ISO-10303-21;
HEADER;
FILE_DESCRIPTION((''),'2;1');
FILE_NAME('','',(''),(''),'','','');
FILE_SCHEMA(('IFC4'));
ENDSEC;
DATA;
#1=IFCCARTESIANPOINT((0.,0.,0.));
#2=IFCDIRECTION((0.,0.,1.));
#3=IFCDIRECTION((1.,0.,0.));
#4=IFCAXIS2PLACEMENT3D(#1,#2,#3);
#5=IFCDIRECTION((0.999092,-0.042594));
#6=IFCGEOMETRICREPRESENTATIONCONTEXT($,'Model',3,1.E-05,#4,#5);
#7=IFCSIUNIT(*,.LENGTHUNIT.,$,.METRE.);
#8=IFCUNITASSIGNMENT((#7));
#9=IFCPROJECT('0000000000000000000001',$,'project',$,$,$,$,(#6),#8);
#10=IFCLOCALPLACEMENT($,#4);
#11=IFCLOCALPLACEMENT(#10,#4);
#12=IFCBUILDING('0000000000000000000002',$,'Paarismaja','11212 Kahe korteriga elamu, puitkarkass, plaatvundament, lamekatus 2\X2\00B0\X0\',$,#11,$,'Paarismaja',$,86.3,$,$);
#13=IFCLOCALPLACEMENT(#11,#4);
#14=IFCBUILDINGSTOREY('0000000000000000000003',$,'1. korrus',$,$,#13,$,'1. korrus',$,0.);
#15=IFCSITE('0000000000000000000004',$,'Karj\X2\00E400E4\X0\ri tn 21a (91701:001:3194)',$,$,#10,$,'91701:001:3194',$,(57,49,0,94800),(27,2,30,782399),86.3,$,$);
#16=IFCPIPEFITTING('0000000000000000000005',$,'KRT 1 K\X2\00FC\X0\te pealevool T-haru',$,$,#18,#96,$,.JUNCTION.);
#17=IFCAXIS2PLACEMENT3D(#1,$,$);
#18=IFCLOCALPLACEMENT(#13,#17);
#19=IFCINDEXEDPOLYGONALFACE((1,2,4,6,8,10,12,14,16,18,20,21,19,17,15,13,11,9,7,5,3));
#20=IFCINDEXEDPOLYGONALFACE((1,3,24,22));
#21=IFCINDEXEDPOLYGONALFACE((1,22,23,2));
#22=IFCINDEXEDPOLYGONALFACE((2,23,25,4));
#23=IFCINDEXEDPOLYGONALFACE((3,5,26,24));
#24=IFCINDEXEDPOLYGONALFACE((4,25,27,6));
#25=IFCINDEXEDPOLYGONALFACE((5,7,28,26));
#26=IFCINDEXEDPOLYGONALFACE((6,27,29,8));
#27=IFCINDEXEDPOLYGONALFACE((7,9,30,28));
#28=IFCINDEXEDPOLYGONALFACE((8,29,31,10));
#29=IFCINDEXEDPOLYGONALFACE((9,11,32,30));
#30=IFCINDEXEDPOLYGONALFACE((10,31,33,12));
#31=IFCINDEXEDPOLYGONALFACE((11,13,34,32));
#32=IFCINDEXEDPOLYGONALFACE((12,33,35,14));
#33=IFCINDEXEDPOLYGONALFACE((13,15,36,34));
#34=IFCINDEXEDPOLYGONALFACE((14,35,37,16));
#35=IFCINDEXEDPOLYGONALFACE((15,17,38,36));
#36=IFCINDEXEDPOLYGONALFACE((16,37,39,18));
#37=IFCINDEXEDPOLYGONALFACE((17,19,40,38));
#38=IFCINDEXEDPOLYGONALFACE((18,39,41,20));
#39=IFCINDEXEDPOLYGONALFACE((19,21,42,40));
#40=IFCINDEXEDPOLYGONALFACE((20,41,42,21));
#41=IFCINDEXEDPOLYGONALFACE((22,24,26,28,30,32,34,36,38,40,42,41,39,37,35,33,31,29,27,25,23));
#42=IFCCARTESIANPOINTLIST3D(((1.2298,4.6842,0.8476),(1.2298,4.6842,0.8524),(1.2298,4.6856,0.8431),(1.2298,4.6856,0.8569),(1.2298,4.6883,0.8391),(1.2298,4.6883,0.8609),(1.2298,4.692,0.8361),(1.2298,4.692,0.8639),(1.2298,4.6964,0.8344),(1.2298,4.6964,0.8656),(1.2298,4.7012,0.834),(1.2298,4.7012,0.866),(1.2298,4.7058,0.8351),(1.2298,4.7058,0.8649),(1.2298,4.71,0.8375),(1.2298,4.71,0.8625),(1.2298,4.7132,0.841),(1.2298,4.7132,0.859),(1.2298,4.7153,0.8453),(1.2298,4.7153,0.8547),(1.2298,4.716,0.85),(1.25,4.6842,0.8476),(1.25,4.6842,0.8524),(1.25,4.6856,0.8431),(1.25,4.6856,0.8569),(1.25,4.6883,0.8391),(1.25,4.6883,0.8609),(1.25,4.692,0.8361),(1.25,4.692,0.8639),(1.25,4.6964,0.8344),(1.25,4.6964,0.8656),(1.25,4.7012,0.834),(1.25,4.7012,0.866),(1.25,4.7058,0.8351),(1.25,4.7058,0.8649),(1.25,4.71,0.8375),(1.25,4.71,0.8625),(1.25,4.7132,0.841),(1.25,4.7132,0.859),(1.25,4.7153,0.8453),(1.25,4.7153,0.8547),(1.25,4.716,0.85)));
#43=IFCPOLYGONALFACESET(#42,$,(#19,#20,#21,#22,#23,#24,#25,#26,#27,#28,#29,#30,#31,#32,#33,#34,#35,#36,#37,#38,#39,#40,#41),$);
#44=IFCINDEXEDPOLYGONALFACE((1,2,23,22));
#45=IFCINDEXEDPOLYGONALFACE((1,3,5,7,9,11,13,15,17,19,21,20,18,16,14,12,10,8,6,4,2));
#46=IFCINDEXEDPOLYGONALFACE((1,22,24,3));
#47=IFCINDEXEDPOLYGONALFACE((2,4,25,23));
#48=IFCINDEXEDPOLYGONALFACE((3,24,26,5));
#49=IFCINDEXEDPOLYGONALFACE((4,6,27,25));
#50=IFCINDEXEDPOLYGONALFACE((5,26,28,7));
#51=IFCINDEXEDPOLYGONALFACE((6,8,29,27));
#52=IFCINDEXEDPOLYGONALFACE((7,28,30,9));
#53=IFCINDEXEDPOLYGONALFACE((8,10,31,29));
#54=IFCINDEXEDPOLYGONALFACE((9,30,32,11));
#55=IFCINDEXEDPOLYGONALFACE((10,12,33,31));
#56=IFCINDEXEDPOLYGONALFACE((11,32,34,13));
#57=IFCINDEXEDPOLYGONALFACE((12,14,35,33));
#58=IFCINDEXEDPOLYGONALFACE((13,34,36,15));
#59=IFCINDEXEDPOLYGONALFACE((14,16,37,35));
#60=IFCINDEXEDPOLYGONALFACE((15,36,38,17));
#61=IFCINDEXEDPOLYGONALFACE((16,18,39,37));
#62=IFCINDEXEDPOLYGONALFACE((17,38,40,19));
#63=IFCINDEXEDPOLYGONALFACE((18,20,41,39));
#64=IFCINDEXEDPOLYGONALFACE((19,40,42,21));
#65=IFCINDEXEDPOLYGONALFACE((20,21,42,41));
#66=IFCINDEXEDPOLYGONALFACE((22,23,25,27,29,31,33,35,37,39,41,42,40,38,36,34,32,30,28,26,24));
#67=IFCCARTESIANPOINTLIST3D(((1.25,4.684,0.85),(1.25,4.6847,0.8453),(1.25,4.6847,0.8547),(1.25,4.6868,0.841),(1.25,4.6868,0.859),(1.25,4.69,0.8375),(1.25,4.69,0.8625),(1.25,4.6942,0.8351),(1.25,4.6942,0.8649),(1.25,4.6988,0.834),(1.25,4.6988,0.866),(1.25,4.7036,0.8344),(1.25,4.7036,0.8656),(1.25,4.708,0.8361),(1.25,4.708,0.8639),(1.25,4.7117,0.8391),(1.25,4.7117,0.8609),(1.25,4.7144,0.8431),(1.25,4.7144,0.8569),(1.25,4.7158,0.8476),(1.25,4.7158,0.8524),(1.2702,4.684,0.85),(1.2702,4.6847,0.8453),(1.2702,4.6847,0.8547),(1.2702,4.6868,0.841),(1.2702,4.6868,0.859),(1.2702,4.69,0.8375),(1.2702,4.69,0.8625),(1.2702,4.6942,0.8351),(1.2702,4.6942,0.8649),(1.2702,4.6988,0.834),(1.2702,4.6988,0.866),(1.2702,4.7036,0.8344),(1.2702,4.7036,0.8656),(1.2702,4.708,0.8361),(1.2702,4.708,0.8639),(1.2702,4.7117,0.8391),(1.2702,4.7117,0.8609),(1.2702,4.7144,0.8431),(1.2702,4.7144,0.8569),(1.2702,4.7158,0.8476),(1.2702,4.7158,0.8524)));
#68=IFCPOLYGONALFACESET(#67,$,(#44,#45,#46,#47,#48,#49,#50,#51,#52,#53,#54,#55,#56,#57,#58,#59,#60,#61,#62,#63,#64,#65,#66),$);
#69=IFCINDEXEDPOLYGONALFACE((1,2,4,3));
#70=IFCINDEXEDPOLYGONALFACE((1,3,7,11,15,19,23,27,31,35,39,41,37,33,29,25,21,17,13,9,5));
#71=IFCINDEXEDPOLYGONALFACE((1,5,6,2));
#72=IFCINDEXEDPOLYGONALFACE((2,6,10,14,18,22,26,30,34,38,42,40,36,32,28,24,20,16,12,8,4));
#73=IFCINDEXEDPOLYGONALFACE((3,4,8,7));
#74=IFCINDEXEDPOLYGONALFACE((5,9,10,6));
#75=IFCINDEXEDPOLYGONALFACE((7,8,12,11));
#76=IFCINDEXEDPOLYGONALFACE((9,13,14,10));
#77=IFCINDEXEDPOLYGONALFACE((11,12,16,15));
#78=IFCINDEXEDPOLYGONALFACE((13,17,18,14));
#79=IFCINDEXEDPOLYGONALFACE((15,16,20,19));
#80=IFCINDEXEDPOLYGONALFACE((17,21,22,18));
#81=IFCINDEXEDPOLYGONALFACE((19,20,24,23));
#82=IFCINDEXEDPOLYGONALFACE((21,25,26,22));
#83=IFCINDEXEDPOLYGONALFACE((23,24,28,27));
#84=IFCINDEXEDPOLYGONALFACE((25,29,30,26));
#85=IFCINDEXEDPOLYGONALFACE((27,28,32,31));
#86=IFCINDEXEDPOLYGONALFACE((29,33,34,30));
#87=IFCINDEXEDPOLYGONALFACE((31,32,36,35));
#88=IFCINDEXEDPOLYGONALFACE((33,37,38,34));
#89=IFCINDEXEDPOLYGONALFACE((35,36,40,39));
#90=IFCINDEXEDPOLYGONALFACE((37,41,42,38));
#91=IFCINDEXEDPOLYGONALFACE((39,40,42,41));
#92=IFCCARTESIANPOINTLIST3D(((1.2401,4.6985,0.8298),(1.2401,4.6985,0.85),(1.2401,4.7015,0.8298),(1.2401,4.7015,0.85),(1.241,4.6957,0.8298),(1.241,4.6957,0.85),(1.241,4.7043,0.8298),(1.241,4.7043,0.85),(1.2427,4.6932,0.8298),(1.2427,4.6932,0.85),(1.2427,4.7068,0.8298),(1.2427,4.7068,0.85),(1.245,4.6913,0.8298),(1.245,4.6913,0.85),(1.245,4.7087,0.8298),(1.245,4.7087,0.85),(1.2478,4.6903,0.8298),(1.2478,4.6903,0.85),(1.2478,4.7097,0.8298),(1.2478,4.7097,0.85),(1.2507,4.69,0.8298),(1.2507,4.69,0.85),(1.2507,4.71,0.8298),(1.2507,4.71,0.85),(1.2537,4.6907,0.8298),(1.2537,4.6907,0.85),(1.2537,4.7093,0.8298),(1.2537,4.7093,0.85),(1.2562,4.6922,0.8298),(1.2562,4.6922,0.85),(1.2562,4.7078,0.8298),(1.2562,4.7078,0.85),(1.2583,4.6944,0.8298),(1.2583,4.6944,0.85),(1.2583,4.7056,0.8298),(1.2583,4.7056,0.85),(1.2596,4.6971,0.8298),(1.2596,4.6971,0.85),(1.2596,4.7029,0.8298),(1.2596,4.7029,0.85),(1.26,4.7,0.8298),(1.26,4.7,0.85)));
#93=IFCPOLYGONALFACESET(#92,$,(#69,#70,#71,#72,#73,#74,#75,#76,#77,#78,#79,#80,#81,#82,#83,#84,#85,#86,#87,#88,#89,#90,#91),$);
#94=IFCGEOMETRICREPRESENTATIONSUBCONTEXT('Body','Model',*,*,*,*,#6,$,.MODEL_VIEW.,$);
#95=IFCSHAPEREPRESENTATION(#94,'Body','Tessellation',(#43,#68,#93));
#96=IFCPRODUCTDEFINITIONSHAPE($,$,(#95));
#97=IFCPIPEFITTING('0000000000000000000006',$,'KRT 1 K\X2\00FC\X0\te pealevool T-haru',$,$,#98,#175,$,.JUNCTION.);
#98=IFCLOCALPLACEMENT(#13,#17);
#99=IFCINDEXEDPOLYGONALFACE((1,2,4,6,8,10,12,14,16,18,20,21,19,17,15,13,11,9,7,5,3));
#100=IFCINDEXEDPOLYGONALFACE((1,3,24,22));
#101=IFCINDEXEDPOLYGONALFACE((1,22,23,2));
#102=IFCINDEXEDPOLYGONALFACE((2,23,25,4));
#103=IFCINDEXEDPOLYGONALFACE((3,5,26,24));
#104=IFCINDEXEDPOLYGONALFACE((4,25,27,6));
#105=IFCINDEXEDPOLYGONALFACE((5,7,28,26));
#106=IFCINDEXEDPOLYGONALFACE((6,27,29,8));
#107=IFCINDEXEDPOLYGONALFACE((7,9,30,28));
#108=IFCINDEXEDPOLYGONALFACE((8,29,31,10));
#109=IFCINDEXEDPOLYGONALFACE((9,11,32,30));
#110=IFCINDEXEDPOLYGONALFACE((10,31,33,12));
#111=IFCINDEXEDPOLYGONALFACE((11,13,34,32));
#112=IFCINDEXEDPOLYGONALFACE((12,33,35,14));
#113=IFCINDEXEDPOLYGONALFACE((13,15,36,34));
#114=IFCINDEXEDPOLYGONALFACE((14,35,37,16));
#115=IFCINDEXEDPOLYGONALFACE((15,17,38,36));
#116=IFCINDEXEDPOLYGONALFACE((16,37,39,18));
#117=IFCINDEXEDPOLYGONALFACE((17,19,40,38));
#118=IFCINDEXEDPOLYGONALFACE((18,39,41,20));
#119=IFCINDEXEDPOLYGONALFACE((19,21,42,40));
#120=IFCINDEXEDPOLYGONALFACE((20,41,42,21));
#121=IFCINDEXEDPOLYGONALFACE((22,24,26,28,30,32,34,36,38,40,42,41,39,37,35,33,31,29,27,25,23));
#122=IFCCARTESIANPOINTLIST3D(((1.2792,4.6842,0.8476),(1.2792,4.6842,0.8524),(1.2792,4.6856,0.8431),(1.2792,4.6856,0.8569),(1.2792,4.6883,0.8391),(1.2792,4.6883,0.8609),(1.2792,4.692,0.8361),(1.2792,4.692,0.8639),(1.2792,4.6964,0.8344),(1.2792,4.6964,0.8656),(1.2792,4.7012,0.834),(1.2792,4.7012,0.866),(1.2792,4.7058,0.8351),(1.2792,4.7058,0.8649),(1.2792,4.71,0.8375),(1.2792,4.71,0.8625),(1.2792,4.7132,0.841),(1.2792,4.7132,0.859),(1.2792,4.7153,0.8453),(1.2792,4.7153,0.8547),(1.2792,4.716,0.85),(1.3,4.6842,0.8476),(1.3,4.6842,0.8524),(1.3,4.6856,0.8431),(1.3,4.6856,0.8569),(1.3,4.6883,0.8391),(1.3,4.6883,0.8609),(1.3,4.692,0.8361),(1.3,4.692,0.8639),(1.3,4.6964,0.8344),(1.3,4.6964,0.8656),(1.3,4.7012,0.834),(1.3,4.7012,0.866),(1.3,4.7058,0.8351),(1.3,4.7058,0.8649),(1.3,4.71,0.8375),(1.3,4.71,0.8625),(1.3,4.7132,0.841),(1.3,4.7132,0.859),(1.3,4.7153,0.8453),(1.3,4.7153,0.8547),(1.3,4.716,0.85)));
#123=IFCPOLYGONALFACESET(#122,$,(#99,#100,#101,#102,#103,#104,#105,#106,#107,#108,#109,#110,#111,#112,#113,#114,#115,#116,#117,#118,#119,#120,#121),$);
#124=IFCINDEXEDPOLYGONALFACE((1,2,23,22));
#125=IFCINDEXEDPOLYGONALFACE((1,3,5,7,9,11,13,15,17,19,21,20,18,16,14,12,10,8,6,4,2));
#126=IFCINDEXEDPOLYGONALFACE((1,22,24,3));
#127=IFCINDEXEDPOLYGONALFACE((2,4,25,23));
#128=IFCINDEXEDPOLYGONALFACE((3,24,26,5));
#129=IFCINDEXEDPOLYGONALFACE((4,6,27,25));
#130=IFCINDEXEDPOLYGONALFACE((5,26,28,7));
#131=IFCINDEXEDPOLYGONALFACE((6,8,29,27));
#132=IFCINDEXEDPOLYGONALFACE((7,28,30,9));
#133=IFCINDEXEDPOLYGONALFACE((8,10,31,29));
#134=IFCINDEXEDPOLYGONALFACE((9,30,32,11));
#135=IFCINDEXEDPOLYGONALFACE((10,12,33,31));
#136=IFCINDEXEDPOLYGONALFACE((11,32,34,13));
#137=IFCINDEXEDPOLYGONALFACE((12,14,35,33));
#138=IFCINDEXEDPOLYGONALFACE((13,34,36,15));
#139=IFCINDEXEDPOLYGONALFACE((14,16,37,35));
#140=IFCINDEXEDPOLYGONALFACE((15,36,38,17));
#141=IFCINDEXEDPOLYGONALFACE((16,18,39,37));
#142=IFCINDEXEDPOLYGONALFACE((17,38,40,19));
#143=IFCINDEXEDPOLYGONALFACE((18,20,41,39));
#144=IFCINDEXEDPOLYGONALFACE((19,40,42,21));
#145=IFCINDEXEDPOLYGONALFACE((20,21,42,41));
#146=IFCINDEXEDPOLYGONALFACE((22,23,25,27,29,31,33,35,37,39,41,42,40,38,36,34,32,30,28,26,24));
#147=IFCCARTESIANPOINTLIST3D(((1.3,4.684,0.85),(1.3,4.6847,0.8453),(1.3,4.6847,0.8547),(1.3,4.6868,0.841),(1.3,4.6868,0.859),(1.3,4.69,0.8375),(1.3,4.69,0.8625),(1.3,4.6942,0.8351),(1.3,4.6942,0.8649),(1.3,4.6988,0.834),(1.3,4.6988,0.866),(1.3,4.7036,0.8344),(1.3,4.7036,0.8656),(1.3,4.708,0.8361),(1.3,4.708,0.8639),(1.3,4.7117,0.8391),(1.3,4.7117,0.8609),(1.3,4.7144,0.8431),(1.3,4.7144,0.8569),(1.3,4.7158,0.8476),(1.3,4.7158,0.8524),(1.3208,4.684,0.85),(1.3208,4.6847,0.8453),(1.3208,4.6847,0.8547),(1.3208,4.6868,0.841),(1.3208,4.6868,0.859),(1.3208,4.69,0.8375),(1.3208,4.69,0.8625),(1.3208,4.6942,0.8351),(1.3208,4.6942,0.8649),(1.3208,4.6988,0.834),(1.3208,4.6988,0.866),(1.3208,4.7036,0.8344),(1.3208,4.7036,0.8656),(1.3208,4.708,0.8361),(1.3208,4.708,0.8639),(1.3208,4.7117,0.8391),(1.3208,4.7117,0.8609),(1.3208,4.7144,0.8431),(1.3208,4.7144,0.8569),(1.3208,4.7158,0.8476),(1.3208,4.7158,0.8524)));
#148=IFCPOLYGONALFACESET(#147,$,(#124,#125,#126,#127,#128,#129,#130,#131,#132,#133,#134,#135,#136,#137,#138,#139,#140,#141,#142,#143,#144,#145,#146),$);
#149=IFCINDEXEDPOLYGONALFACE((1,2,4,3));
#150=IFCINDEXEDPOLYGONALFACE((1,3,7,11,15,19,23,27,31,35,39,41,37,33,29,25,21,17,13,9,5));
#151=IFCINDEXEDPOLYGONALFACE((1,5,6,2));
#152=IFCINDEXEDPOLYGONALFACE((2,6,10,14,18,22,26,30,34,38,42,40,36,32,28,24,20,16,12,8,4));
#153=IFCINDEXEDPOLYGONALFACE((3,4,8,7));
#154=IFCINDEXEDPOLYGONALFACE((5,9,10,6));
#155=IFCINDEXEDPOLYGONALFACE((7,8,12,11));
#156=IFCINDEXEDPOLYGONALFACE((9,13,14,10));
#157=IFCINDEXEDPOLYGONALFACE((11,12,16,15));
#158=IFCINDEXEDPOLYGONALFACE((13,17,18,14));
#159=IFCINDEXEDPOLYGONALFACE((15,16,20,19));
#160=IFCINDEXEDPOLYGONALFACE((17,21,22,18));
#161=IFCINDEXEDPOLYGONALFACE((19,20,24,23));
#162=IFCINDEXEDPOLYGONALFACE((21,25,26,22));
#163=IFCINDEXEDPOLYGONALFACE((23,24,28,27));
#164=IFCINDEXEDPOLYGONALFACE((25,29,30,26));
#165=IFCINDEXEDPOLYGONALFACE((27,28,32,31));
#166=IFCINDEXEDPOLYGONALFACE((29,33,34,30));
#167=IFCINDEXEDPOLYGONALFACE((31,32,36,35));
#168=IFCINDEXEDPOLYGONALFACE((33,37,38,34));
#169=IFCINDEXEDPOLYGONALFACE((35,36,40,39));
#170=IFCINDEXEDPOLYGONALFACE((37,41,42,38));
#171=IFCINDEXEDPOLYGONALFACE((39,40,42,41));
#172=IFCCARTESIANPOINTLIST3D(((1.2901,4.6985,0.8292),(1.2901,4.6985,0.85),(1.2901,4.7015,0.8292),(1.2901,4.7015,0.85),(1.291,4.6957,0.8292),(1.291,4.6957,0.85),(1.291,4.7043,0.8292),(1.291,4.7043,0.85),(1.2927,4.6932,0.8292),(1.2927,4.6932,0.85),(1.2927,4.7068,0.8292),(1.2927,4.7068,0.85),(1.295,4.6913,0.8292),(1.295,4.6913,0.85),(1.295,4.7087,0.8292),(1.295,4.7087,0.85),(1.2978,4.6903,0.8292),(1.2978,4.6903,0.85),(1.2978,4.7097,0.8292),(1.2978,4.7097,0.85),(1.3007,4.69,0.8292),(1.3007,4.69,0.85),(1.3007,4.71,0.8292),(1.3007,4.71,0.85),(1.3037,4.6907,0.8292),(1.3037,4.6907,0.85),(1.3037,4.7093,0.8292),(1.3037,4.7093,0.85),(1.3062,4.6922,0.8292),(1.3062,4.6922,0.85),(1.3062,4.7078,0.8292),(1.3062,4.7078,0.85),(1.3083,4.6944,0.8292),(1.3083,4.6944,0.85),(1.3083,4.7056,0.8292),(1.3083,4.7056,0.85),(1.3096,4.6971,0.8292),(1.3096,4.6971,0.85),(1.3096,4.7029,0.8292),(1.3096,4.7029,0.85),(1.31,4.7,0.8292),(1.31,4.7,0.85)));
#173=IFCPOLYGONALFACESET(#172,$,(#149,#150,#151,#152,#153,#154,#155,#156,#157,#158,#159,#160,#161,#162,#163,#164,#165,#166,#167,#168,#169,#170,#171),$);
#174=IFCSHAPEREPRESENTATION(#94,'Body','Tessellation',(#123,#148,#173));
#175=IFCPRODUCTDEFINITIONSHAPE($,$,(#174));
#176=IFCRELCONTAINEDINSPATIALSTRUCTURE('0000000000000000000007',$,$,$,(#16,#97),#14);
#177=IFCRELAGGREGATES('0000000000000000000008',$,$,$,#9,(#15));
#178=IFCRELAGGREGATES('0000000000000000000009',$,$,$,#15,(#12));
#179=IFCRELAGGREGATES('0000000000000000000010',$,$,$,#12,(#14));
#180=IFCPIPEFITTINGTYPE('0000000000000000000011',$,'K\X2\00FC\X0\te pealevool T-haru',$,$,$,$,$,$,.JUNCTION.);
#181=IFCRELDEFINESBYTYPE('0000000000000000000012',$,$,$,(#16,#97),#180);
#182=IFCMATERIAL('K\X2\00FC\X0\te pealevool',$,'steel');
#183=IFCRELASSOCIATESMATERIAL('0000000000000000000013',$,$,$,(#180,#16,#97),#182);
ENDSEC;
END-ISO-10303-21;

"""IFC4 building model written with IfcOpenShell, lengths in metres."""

from ifc_helpers import new_model, si_unit, direction, frame, origin_with_axes, place, context, subcontext, project, spatial, circle, extrude, material, type_object, element, save


model = new_model("IFC4")

# Units and contexts
model_context = context("Model", 3, precision=1e-05, world=origin_with_axes(), true_north=direction((0.999092, -0.042594)))
body_context = subcontext(model_context, "Body", "Model", "MODEL_VIEW")
ifc_project = project(units=[si_unit("LENGTHUNIT", "METRE")], contexts=[model_context])

# Site, building, storey
site_placement = place(None, origin_with_axes())
site = spatial("IfcSite", under=ifc_project, at=site_placement, Name="Karjääri tn 21a (91701:001:3194)", LongName="91701:001:3194", RefLatitude=(57, 49, 0, 94800), RefLongitude=(27, 2, 30, 782399), RefElevation=86.3)
building_placement = place(site_placement, origin_with_axes())
building = spatial("IfcBuilding", under=site, at=building_placement, Name="Paarismaja", Description="11212 Kahe korteriga elamu, puitkarkass, plaatvundament, lamekatus 2°", LongName="Paarismaja", ElevationOfRefHeight=86.3)
storey_placement = place(building_placement, origin_with_axes())
storey = spatial("IfcBuildingStorey", under=building, at=storey_placement, Name="1. korrus", LongName="1. korrus", Elevation=0.0)

# Pipe fittings
ifc_material_1 = material(Name="Küte pealevool", Category="steel")
pipe_fitting_type_1 = type_object("IfcPipeFittingType", Name="Küte pealevool T-haru", PredefinedType="JUNCTION", material=ifc_material_1)
pipe_fitting_1_placement = place(storey_placement, frame((1.25, 4.7, 0.85), z_axis=(0.0, 0.0, 1.0), x_axis=(1.0, 0.0, 0.0)))
element("IfcPipeFitting", 1, at=pipe_fitting_1_placement, inside=storey, type_object=pipe_fitting_type_1, material=ifc_material_1, Name="KRT 1 Küte pealevool T-haru", PredefinedType="JUNCTION", context=body_context, shape_type="SweptSolid", body=[
    extrude(circle(Radius=0.016), frame((0.0, 0.0, 0.0), z_axis=(-1.0, 0.0, 0.0), x_axis=(0.0, 1.0, 0.0)), (0.0, 0.0, 1.0), 0.0202),
    extrude(circle(Radius=0.016), frame((0.0, 0.0, 0.0), z_axis=(1.0, 0.0, 0.0), x_axis=(0.0, -1.0, 0.0)), (0.0, 0.0, 1.0), 0.0202),
    extrude(circle(Radius=0.01), frame((0.0, 0.0, 0.0), z_axis=(0.0, 0.0, -1.0), x_axis=(1.0, 0.0, 0.0)), (0.0, 0.0, 1.0), 0.0202),
])
for number, where, z_axis, x_axis, name in (
    (2, (1.3, 4.7, 0.85), (0.0, 0.0, 1.0), (1.0, 0.0, 0.0), "KRT 1 Küte pealevool T-haru"),
):
    element("IfcPipeFitting", number, at=place(storey_placement, frame(where, z_axis=z_axis, x_axis=x_axis)), inside=storey, type_object=pipe_fitting_type_1, material=ifc_material_1, Name=name, PredefinedType="JUNCTION", context=body_context, shape_type="SweptSolid", body=[
        extrude(circle(Radius=0.016), frame((0.0, 0.0, 0.0), z_axis=(-1.0, 0.0, 0.0), x_axis=(0.0, 1.0, 0.0)), (0.0, 0.0, 1.0), 0.0208),
        extrude(circle(Radius=0.016), frame((0.0, 0.0, 0.0), z_axis=(1.0, 0.0, 0.0), x_axis=(0.0, -1.0, 0.0)), (0.0, 0.0, 1.0), 0.0208),
        extrude(circle(Radius=0.01), frame((0.0, 0.0, 0.0), z_axis=(0.0, 0.0, -1.0), x_axis=(1.0, 0.0, 0.0)), (0.0, 0.0, 1.0), 0.0208),
    ])

save(model, "model.ifc")
